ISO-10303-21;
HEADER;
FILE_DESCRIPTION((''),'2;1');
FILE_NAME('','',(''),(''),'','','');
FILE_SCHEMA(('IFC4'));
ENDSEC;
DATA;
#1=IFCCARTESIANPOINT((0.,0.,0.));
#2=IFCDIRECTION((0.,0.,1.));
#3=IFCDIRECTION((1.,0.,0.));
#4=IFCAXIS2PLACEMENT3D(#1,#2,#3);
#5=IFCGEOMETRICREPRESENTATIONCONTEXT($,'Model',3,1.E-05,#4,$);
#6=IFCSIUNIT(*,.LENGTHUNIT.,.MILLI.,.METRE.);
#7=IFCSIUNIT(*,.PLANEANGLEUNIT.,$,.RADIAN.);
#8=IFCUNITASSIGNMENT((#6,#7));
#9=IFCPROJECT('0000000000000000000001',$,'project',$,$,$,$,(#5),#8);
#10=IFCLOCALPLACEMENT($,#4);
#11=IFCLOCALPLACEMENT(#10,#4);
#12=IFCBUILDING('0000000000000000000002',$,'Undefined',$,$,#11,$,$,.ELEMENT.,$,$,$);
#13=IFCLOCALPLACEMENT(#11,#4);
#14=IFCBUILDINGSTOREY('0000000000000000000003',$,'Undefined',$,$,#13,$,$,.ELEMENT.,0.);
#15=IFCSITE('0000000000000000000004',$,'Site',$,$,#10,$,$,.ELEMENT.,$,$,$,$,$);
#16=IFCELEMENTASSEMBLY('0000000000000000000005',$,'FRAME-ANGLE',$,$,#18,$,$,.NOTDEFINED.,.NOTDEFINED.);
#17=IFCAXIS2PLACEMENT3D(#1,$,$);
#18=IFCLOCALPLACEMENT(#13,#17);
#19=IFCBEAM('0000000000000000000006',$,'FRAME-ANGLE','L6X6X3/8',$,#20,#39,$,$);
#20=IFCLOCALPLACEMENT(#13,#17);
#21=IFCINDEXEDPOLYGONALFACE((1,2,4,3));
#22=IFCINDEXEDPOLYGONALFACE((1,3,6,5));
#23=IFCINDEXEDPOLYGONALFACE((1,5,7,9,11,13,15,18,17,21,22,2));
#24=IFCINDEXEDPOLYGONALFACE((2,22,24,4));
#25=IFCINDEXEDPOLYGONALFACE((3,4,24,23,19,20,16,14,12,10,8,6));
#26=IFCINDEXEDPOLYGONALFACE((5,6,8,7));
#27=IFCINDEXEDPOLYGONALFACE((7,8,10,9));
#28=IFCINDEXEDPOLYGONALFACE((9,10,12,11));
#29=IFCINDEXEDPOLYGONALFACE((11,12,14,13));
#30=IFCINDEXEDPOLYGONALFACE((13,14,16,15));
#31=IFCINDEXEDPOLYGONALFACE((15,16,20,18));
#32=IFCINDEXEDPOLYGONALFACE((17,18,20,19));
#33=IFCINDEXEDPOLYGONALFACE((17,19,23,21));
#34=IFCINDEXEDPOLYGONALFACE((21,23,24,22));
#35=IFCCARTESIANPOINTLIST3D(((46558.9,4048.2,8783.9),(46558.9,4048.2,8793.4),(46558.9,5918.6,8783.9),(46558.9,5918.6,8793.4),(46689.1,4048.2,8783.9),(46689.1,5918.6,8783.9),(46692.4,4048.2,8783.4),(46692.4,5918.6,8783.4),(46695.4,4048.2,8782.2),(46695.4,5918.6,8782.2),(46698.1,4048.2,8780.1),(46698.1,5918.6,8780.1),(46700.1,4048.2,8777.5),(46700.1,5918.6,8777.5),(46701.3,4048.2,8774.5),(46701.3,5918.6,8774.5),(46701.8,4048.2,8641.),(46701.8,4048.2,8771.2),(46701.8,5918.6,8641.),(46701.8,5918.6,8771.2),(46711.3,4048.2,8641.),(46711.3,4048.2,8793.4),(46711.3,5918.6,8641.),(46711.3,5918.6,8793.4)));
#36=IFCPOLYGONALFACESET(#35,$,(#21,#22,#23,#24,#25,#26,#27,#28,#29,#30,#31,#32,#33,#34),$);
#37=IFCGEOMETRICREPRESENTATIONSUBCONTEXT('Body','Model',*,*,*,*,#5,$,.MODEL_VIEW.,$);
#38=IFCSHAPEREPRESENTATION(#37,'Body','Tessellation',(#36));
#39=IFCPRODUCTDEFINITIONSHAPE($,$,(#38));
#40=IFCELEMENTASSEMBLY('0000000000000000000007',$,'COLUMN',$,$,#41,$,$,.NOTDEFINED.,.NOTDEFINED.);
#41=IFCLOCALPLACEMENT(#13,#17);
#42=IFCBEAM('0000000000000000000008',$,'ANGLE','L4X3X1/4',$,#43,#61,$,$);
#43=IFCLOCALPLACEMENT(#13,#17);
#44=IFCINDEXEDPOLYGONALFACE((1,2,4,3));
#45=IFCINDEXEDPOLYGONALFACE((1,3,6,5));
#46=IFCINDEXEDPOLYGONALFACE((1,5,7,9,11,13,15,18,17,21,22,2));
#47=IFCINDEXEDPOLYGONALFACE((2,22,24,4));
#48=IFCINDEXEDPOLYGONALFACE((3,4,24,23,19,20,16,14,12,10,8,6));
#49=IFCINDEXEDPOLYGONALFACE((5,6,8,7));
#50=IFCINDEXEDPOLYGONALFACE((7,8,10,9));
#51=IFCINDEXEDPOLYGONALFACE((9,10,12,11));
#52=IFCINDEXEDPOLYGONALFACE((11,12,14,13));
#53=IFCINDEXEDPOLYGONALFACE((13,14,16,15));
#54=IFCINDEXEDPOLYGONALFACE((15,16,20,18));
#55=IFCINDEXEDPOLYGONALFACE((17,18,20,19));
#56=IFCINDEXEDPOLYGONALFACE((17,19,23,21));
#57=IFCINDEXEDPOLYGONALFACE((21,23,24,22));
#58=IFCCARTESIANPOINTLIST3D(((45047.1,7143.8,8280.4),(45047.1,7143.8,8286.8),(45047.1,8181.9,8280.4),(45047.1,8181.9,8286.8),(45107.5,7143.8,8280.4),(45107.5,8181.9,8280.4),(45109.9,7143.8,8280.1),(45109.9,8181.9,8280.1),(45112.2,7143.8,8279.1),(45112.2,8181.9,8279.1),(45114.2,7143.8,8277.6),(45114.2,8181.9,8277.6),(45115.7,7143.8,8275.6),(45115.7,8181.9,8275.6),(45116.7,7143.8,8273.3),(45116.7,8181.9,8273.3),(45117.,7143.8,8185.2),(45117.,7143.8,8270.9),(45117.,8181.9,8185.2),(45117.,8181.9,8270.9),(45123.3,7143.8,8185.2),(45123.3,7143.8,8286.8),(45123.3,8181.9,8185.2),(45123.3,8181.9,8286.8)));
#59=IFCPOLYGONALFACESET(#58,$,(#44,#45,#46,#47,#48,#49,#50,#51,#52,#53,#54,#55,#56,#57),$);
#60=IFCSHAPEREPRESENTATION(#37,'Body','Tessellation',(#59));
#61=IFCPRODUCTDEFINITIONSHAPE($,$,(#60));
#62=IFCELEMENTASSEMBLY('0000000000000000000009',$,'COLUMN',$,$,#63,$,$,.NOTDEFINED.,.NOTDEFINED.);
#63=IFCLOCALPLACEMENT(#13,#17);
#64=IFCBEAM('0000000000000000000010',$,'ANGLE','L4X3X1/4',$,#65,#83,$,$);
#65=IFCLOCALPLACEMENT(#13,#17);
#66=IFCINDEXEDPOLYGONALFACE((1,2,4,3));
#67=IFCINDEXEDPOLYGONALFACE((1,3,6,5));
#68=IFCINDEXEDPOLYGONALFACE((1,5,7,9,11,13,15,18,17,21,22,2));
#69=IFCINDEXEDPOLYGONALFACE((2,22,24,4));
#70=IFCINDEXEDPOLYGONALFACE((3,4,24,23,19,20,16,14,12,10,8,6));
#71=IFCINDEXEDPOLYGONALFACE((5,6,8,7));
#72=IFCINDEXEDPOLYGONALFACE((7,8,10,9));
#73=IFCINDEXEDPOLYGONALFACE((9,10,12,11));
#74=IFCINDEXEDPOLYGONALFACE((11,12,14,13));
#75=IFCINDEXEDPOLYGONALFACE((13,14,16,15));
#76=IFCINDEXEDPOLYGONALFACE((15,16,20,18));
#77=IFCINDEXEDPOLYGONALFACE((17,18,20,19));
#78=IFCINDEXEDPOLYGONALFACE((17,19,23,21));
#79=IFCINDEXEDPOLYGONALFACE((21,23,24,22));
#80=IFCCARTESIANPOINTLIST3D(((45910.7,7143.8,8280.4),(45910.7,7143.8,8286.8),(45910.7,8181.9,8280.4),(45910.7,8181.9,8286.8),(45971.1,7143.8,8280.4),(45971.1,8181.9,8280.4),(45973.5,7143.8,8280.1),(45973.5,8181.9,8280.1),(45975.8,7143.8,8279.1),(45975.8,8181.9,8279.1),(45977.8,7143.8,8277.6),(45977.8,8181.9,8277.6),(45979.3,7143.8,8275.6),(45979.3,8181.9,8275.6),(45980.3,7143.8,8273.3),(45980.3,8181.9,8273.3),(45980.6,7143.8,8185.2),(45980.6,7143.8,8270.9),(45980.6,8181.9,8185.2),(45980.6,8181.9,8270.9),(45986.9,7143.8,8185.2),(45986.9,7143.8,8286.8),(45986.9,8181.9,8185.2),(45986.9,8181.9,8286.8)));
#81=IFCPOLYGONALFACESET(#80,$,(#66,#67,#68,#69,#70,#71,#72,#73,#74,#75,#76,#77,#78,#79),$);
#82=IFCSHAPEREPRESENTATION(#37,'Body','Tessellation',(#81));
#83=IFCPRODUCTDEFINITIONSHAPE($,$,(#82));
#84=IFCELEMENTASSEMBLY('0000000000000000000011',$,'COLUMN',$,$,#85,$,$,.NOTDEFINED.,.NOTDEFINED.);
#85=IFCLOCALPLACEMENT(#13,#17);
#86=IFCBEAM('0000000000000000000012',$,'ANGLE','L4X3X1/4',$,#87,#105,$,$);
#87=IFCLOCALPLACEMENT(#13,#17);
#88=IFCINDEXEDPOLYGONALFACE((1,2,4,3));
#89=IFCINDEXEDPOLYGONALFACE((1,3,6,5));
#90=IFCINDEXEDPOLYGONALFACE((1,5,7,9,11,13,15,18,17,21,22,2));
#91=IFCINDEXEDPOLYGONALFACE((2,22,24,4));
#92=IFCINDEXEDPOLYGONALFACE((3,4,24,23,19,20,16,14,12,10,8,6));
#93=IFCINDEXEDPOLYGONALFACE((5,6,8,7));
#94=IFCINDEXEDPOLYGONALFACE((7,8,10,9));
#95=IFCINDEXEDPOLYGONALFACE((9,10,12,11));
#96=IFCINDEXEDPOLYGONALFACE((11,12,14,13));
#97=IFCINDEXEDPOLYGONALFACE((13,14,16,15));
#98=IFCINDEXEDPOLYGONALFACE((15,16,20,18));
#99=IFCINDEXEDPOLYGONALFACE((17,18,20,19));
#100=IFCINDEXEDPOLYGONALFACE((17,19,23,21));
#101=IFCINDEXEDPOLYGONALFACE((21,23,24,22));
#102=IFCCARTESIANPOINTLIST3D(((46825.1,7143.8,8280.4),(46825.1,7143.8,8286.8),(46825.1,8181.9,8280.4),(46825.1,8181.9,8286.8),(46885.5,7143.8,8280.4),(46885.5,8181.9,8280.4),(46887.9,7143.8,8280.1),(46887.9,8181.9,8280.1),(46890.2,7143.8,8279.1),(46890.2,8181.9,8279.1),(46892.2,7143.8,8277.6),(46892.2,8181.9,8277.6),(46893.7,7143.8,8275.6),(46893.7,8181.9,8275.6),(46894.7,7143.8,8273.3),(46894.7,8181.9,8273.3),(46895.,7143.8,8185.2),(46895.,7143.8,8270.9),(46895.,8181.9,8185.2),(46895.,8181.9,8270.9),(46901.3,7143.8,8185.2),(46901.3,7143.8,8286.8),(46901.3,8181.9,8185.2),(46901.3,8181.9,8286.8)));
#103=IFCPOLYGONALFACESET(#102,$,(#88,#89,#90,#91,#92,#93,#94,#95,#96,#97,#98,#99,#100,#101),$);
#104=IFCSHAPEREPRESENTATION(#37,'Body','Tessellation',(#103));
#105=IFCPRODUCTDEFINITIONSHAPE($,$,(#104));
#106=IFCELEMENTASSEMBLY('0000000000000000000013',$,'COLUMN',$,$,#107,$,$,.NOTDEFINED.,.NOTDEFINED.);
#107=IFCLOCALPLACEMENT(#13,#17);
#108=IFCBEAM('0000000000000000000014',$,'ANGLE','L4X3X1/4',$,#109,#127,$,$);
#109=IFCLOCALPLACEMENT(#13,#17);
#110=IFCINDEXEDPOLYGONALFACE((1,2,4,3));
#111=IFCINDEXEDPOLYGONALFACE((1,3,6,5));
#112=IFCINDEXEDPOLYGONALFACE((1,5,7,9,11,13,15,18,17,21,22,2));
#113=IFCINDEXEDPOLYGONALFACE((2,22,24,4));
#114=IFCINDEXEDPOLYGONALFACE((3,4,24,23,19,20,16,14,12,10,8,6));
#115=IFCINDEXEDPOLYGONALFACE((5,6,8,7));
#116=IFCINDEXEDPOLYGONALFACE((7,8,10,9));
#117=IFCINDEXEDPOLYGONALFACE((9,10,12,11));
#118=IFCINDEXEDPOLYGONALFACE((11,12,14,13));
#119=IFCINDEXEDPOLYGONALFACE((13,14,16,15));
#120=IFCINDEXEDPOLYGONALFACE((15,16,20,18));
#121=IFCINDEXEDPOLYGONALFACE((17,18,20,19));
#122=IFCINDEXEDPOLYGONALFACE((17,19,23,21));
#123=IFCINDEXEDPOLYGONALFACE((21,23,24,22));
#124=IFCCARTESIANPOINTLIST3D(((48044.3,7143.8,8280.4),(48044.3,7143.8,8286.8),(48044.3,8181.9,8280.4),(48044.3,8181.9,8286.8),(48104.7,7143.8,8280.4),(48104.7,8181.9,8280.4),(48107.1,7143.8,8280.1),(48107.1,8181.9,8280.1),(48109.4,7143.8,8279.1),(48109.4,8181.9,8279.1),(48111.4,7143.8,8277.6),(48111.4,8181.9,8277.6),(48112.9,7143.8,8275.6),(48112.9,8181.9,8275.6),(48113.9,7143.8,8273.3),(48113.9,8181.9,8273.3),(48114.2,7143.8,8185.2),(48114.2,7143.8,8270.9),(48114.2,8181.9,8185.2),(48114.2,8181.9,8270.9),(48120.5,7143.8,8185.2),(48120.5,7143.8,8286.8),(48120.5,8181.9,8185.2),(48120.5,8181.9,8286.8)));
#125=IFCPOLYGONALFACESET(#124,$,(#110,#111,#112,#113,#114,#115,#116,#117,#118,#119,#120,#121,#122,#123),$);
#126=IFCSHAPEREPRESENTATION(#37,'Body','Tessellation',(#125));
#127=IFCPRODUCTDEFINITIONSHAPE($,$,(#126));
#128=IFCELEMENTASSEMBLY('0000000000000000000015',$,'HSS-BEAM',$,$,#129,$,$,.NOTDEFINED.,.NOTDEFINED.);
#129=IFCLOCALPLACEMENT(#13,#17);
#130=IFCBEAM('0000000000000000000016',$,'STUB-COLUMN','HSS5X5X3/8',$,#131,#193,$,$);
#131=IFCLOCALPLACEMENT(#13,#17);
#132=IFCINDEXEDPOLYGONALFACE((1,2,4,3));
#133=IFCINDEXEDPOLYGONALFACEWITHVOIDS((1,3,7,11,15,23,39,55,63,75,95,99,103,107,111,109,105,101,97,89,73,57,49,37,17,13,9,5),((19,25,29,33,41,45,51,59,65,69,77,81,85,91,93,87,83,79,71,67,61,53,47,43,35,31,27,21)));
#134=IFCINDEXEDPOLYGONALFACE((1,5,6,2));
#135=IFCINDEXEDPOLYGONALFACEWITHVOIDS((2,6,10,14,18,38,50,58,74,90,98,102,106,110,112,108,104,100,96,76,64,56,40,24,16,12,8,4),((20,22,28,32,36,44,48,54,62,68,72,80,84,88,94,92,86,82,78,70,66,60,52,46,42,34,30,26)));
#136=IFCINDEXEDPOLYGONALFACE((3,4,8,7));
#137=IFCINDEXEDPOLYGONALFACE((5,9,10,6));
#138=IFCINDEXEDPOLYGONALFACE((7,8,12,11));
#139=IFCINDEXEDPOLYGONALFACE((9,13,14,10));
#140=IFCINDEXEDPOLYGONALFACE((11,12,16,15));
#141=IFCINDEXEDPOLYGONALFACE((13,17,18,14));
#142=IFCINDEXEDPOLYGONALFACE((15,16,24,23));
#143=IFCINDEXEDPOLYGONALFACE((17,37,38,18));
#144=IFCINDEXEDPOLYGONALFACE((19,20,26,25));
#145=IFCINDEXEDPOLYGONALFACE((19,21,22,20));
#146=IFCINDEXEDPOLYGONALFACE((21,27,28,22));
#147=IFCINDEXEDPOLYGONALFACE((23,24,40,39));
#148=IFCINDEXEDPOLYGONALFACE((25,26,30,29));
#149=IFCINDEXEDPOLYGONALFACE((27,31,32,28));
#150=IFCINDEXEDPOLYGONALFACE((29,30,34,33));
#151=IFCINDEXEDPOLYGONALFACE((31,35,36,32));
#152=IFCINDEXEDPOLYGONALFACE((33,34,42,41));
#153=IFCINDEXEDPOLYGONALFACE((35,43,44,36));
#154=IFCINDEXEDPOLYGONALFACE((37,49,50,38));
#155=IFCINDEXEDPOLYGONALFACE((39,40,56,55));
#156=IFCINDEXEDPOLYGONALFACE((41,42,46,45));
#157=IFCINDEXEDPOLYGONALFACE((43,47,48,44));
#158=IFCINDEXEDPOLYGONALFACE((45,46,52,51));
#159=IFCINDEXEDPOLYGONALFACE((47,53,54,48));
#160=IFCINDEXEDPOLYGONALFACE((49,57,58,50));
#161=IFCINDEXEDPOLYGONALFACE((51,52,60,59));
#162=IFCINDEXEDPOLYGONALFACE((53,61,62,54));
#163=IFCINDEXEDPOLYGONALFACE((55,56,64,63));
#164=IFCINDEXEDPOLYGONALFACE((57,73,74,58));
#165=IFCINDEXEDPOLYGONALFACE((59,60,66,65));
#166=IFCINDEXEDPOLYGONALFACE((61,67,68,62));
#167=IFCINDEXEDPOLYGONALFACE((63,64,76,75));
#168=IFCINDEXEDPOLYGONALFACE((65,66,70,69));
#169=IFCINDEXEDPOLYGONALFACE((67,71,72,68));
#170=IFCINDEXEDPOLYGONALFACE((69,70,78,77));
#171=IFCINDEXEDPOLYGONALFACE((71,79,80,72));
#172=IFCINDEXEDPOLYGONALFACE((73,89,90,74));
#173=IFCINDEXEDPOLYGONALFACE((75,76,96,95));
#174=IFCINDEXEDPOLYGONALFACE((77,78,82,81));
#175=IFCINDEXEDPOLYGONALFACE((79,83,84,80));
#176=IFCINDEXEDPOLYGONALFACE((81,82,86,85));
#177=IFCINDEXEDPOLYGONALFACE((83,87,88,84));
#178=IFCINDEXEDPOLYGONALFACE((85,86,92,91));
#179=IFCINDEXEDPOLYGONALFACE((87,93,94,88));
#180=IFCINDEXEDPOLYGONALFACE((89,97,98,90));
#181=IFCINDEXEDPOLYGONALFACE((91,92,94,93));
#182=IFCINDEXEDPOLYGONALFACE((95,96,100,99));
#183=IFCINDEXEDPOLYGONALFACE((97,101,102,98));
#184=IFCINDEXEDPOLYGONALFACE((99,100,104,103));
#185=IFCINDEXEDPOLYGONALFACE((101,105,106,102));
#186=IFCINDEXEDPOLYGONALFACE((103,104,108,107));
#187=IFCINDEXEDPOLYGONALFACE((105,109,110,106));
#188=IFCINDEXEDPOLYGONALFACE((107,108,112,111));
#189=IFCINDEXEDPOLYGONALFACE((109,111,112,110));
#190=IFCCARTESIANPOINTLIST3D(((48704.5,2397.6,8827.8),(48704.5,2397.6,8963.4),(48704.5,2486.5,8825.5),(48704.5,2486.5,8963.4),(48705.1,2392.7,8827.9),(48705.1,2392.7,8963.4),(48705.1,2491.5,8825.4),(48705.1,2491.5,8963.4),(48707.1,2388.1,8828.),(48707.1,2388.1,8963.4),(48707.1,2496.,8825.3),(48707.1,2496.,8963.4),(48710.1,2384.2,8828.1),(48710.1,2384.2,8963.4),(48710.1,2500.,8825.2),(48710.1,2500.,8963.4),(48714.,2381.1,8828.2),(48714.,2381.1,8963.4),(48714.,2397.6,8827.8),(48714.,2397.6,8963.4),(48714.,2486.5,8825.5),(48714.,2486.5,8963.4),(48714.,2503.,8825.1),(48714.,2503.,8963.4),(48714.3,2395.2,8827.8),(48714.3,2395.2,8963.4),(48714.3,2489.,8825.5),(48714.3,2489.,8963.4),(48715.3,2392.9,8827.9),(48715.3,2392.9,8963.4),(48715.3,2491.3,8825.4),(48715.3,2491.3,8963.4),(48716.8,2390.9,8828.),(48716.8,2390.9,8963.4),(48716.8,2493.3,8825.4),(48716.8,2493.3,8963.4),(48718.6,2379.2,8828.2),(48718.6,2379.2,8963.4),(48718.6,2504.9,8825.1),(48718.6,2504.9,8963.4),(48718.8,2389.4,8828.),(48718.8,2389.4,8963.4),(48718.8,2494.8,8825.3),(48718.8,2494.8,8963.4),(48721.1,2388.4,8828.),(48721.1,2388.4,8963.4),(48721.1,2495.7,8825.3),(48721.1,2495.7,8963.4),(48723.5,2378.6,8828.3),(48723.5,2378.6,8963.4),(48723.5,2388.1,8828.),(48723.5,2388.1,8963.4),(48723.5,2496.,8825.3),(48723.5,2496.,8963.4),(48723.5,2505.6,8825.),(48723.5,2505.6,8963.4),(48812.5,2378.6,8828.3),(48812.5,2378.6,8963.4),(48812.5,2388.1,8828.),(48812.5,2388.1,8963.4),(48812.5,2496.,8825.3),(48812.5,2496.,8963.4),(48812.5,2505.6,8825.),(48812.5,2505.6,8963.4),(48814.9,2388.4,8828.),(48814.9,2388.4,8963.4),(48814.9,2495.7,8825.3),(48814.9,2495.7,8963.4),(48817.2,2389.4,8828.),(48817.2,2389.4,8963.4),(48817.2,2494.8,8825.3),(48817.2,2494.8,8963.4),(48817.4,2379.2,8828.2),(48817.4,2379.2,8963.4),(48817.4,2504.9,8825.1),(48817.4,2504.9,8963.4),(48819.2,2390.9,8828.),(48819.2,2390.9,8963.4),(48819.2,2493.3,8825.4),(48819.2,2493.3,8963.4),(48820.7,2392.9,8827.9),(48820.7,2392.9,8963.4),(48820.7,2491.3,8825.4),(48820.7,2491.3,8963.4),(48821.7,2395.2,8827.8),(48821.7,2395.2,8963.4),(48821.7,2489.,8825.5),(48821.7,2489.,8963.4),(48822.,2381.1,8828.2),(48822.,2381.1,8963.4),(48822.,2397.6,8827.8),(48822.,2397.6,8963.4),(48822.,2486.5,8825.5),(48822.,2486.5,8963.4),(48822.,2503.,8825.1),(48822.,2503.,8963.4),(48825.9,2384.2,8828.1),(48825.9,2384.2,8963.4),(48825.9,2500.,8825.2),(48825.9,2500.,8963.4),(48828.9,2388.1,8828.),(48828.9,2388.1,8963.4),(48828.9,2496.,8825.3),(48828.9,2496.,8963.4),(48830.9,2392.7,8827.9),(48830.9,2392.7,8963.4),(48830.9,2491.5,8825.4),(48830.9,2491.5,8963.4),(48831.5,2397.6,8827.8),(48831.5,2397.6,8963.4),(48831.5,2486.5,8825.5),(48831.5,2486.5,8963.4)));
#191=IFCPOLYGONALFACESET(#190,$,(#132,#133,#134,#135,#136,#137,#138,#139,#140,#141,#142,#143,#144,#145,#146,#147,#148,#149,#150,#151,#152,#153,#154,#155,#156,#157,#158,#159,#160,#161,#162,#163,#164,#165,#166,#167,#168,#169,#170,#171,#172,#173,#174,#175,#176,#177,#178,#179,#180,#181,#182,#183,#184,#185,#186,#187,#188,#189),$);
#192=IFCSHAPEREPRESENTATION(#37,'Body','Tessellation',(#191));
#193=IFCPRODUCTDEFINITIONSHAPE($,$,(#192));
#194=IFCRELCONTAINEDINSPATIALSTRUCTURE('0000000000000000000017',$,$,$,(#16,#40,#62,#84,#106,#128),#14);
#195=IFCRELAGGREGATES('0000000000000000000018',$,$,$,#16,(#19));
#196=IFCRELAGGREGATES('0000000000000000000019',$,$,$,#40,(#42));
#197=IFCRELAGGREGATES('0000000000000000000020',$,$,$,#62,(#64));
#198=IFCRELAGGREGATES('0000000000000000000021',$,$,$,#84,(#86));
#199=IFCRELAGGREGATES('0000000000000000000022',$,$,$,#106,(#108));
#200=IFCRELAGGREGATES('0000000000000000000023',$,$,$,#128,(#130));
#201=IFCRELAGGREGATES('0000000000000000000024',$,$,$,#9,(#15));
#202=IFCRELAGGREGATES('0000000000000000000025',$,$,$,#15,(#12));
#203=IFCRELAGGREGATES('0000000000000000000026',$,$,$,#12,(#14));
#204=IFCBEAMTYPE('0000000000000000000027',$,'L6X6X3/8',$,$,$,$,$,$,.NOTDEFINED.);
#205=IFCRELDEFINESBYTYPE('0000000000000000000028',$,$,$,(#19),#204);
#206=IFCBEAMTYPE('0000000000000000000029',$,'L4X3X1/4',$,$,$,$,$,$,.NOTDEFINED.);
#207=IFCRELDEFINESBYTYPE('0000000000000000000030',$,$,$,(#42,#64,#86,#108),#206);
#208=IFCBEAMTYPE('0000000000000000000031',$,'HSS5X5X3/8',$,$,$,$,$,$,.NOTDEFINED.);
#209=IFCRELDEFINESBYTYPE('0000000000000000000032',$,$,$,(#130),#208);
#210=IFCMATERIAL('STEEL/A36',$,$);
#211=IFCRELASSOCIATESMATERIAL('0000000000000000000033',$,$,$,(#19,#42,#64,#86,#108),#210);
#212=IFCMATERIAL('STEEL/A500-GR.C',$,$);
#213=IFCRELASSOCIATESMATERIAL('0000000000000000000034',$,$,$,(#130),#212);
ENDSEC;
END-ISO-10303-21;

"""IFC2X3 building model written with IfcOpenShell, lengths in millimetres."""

from ifc_helpers import new_model, si_unit, frame, origin_with_axes, origin_2d_with_axis, place, context, subcontext, project, spatial, hollow_rectangle, l_section, extrude, clip, halfspace, material, type_object, element, aggregate, save


model = new_model("IFC2X3")

# Units and contexts
model_context = context("Model", 3, precision=1e-05, world=origin_with_axes())
body_context = subcontext(model_context, "Body", "Model", "MODEL_VIEW")
ifc_project = project(units=[si_unit("LENGTHUNIT", "METRE", prefix="MILLI"), si_unit("PLANEANGLEUNIT", "RADIAN")], contexts=[model_context])

# Site, building, storey
site_placement = place(None, origin_with_axes())
site = spatial("IfcSite", under=ifc_project, at=site_placement, Name="Site", CompositionType="ELEMENT")
building_placement = place(site_placement, origin_with_axes())
building = spatial("IfcBuilding", under=site, at=building_placement, Name="Undefined", CompositionType="ELEMENT")
storey_placement = place(building_placement, origin_with_axes())
storey = spatial("IfcBuildingStorey", under=building, at=storey_placement, Name="Undefined", CompositionType="ELEMENT", Elevation=0.0)

# Element assembly, beam
assembly_1_placement = place(storey_placement, origin_with_axes())
assembly_1 = element("IfcElementAssembly", 1, at=assembly_1_placement, inside=storey, Name="FRAME-ANGLE", AssemblyPlace="NOTDEFINED", PredefinedType="NOTDEFINED")
ifc_material_1 = material(Name="STEEL/A36")
beam_type_1 = type_object("IfcBeamType", Name="L6X6X3/8", PredefinedType="NOTDEFINED")
beam_1_placement = place(assembly_1_placement, frame((46635.1, 4048.2, 8717.2), z_axis=(0.0, 0.0, -1.0), x_axis=(-0.000001, 1.0, 0.0)))
beam_1 = element("IfcBeam", 2, at=beam_1_placement, type_object=beam_type_1, material=ifc_material_1, Name="FRAME-ANGLE", Description="L6X6X3/8", context=body_context, shape_type="Clipping", body=[
    clip(clip(extrude(l_section(Depth=152.4, Width=152.4, Thickness=9.5, FilletRadius=12.7, at=origin_2d_with_axis()), frame((1870.4, 0.0, 0.0), z_axis=(-1.0, 0.0, 0.0), x_axis=(0.0, -1.0, 0.0)), (0.0, 0.0, 1.0), 1870.4), halfspace(frame((1870.4, 0.0, 1000.0), z_axis=(-1.0, -0.000001, 0.0), x_axis=(0.000001, -1.0, 0.0)), True)), halfspace(frame((0.0, 0.0, 1000.0), z_axis=(1.0, 0.000002, 0.0), x_axis=(-0.000001, 1.0, 0.0)), True)),
])
aggregate(assembly_1, [beam_1])

# Element assemblies, beams
assembly_2_placement = place(storey_placement, origin_with_axes())
assembly_2 = element("IfcElementAssembly", 3, at=assembly_2_placement, inside=storey, Name="COLUMN", AssemblyPlace="NOTDEFINED", PredefinedType="NOTDEFINED")
beam_type_2 = type_object("IfcBeamType", Name="L4X3X1/4", PredefinedType="NOTDEFINED")
beam_2_placement = place(assembly_2_placement, frame((45085.2, 7143.8, 8236.0), z_axis=(0.0, 0.0, -1.0), x_axis=(0.0, 1.0, 0.0)))
beam_2 = element("IfcBeam", 4, at=beam_2_placement, type_object=beam_type_2, material=ifc_material_1, Name="ANGLE", Description="L4X3X1/4", context=body_context, shape_type="SweptSolid", body=[
    extrude(l_section(Depth=101.6, Width=76.2, Thickness=6.3, FilletRadius=9.5, at=origin_2d_with_axis()), frame((1038.2, 0.0, 0.0), z_axis=(-1.0, 0.0, 0.0), x_axis=(0.0, -1.0, 0.0)), (0.0, 0.0, 1.0), 1038.2),
])
aggregate(assembly_2, [beam_2])
assembly_3_placement = place(storey_placement, origin_with_axes())
assembly_3 = element("IfcElementAssembly", 5, at=assembly_3_placement, inside=storey, Name="COLUMN", AssemblyPlace="NOTDEFINED", PredefinedType="NOTDEFINED")
beam_3_placement = place(assembly_3_placement, frame((45948.8, 7143.8, 8236.0), z_axis=(0.0, 0.0, -1.0), x_axis=(0.0, 1.0, 0.0)))
beam_3 = element("IfcBeam", 6, at=beam_3_placement, type_object=beam_type_2, material=ifc_material_1, Name="ANGLE", Description="L4X3X1/4", context=body_context, shape_type="SweptSolid", body=[
    extrude(l_section(Depth=101.6, Width=76.2, Thickness=6.3, FilletRadius=9.5, at=origin_2d_with_axis()), frame((1038.2, 0.0, 0.0), z_axis=(-1.0, 0.0, 0.0), x_axis=(0.0, -1.0, 0.0)), (0.0, 0.0, 1.0), 1038.2),
])
aggregate(assembly_3, [beam_3])
assembly_4_placement = place(storey_placement, origin_with_axes())
assembly_4 = element("IfcElementAssembly", 7, at=assembly_4_placement, inside=storey, Name="COLUMN", AssemblyPlace="NOTDEFINED", PredefinedType="NOTDEFINED")
beam_4_placement = place(assembly_4_placement, frame((46863.2, 7143.8, 8236.0), z_axis=(0.0, 0.0, -1.0), x_axis=(0.0, 1.0, 0.0)))
beam_4 = element("IfcBeam", 8, at=beam_4_placement, type_object=beam_type_2, material=ifc_material_1, Name="ANGLE", Description="L4X3X1/4", context=body_context, shape_type="SweptSolid", body=[
    extrude(l_section(Depth=101.6, Width=76.2, Thickness=6.3, FilletRadius=9.5, at=origin_2d_with_axis()), frame((1038.2, 0.0, 0.0), z_axis=(-1.0, 0.0, 0.0), x_axis=(0.0, -1.0, 0.0)), (0.0, 0.0, 1.0), 1038.2),
])
aggregate(assembly_4, [beam_4])
assembly_5_placement = place(storey_placement, origin_with_axes())
assembly_5 = element("IfcElementAssembly", 9, at=assembly_5_placement, inside=storey, Name="COLUMN", AssemblyPlace="NOTDEFINED", PredefinedType="NOTDEFINED")
beam_5_placement = place(assembly_5_placement, frame((48082.4, 7143.8, 8236.0), z_axis=(0.0, 0.0, -1.0), x_axis=(0.0, 1.0, 0.0)))
beam_5 = element("IfcBeam", 10, at=beam_5_placement, type_object=beam_type_2, material=ifc_material_1, Name="ANGLE", Description="L4X3X1/4", context=body_context, shape_type="SweptSolid", body=[
    extrude(l_section(Depth=101.6, Width=76.2, Thickness=6.3, FilletRadius=9.5, at=origin_2d_with_axis()), frame((1038.2, 0.0, 0.0), z_axis=(-1.0, 0.0, 0.0), x_axis=(0.0, -1.0, 0.0)), (0.0, 0.0, 1.0), 1038.2),
])
aggregate(assembly_5, [beam_5])

# Element assembly, beam
assembly_6_placement = place(storey_placement, origin_with_axes())
assembly_6 = element("IfcElementAssembly", 11, at=assembly_6_placement, inside=storey, Name="HSS-BEAM", AssemblyPlace="NOTDEFINED", PredefinedType="NOTDEFINED")
ifc_material_2 = material(Name="STEEL/A500-GR.C")
beam_type_3 = type_object("IfcBeamType", Name="HSS5X5X3/8", PredefinedType="NOTDEFINED")
beam_6_placement = place(assembly_6_placement, frame((48768.0, 2442.1, 8963.4), z_axis=(1.0, 0.0, 0.0), x_axis=(0.0, 0.0, -1.0)))
beam_6 = element("IfcBeam", 12, at=beam_6_placement, type_object=beam_type_3, material=ifc_material_2, Name="STUB-COLUMN", Description="HSS5X5X3/8", context=body_context, shape_type="Clipping", body=[
    clip(clip(extrude(hollow_rectangle(XDim=127.0, YDim=127.0, WallThickness=9.5, InnerFilletRadius=9.5, OuterFilletRadius=19.0, at=origin_2d_with_axis()), frame((155.8, 0.0, 0.0), z_axis=(-1.0, 0.0, 0.0), x_axis=(0.0, -1.0, 0.0)), (0.0, 0.0, 1.0), 157.4), halfspace(frame((136.7, 0.0, -63.5), z_axis=(-0.99968, 0.025308, 0.0), x_axis=(0.025308, 0.99968, 0.0)), True)), halfspace(frame((0.0, 0.0, -1000.0), z_axis=(1.0, 0.0, 0.0), x_axis=(0.0, -1.0, 0.0)), True)),
])

aggregate(assembly_6, [beam_6])

save(model, "model.ifc")
